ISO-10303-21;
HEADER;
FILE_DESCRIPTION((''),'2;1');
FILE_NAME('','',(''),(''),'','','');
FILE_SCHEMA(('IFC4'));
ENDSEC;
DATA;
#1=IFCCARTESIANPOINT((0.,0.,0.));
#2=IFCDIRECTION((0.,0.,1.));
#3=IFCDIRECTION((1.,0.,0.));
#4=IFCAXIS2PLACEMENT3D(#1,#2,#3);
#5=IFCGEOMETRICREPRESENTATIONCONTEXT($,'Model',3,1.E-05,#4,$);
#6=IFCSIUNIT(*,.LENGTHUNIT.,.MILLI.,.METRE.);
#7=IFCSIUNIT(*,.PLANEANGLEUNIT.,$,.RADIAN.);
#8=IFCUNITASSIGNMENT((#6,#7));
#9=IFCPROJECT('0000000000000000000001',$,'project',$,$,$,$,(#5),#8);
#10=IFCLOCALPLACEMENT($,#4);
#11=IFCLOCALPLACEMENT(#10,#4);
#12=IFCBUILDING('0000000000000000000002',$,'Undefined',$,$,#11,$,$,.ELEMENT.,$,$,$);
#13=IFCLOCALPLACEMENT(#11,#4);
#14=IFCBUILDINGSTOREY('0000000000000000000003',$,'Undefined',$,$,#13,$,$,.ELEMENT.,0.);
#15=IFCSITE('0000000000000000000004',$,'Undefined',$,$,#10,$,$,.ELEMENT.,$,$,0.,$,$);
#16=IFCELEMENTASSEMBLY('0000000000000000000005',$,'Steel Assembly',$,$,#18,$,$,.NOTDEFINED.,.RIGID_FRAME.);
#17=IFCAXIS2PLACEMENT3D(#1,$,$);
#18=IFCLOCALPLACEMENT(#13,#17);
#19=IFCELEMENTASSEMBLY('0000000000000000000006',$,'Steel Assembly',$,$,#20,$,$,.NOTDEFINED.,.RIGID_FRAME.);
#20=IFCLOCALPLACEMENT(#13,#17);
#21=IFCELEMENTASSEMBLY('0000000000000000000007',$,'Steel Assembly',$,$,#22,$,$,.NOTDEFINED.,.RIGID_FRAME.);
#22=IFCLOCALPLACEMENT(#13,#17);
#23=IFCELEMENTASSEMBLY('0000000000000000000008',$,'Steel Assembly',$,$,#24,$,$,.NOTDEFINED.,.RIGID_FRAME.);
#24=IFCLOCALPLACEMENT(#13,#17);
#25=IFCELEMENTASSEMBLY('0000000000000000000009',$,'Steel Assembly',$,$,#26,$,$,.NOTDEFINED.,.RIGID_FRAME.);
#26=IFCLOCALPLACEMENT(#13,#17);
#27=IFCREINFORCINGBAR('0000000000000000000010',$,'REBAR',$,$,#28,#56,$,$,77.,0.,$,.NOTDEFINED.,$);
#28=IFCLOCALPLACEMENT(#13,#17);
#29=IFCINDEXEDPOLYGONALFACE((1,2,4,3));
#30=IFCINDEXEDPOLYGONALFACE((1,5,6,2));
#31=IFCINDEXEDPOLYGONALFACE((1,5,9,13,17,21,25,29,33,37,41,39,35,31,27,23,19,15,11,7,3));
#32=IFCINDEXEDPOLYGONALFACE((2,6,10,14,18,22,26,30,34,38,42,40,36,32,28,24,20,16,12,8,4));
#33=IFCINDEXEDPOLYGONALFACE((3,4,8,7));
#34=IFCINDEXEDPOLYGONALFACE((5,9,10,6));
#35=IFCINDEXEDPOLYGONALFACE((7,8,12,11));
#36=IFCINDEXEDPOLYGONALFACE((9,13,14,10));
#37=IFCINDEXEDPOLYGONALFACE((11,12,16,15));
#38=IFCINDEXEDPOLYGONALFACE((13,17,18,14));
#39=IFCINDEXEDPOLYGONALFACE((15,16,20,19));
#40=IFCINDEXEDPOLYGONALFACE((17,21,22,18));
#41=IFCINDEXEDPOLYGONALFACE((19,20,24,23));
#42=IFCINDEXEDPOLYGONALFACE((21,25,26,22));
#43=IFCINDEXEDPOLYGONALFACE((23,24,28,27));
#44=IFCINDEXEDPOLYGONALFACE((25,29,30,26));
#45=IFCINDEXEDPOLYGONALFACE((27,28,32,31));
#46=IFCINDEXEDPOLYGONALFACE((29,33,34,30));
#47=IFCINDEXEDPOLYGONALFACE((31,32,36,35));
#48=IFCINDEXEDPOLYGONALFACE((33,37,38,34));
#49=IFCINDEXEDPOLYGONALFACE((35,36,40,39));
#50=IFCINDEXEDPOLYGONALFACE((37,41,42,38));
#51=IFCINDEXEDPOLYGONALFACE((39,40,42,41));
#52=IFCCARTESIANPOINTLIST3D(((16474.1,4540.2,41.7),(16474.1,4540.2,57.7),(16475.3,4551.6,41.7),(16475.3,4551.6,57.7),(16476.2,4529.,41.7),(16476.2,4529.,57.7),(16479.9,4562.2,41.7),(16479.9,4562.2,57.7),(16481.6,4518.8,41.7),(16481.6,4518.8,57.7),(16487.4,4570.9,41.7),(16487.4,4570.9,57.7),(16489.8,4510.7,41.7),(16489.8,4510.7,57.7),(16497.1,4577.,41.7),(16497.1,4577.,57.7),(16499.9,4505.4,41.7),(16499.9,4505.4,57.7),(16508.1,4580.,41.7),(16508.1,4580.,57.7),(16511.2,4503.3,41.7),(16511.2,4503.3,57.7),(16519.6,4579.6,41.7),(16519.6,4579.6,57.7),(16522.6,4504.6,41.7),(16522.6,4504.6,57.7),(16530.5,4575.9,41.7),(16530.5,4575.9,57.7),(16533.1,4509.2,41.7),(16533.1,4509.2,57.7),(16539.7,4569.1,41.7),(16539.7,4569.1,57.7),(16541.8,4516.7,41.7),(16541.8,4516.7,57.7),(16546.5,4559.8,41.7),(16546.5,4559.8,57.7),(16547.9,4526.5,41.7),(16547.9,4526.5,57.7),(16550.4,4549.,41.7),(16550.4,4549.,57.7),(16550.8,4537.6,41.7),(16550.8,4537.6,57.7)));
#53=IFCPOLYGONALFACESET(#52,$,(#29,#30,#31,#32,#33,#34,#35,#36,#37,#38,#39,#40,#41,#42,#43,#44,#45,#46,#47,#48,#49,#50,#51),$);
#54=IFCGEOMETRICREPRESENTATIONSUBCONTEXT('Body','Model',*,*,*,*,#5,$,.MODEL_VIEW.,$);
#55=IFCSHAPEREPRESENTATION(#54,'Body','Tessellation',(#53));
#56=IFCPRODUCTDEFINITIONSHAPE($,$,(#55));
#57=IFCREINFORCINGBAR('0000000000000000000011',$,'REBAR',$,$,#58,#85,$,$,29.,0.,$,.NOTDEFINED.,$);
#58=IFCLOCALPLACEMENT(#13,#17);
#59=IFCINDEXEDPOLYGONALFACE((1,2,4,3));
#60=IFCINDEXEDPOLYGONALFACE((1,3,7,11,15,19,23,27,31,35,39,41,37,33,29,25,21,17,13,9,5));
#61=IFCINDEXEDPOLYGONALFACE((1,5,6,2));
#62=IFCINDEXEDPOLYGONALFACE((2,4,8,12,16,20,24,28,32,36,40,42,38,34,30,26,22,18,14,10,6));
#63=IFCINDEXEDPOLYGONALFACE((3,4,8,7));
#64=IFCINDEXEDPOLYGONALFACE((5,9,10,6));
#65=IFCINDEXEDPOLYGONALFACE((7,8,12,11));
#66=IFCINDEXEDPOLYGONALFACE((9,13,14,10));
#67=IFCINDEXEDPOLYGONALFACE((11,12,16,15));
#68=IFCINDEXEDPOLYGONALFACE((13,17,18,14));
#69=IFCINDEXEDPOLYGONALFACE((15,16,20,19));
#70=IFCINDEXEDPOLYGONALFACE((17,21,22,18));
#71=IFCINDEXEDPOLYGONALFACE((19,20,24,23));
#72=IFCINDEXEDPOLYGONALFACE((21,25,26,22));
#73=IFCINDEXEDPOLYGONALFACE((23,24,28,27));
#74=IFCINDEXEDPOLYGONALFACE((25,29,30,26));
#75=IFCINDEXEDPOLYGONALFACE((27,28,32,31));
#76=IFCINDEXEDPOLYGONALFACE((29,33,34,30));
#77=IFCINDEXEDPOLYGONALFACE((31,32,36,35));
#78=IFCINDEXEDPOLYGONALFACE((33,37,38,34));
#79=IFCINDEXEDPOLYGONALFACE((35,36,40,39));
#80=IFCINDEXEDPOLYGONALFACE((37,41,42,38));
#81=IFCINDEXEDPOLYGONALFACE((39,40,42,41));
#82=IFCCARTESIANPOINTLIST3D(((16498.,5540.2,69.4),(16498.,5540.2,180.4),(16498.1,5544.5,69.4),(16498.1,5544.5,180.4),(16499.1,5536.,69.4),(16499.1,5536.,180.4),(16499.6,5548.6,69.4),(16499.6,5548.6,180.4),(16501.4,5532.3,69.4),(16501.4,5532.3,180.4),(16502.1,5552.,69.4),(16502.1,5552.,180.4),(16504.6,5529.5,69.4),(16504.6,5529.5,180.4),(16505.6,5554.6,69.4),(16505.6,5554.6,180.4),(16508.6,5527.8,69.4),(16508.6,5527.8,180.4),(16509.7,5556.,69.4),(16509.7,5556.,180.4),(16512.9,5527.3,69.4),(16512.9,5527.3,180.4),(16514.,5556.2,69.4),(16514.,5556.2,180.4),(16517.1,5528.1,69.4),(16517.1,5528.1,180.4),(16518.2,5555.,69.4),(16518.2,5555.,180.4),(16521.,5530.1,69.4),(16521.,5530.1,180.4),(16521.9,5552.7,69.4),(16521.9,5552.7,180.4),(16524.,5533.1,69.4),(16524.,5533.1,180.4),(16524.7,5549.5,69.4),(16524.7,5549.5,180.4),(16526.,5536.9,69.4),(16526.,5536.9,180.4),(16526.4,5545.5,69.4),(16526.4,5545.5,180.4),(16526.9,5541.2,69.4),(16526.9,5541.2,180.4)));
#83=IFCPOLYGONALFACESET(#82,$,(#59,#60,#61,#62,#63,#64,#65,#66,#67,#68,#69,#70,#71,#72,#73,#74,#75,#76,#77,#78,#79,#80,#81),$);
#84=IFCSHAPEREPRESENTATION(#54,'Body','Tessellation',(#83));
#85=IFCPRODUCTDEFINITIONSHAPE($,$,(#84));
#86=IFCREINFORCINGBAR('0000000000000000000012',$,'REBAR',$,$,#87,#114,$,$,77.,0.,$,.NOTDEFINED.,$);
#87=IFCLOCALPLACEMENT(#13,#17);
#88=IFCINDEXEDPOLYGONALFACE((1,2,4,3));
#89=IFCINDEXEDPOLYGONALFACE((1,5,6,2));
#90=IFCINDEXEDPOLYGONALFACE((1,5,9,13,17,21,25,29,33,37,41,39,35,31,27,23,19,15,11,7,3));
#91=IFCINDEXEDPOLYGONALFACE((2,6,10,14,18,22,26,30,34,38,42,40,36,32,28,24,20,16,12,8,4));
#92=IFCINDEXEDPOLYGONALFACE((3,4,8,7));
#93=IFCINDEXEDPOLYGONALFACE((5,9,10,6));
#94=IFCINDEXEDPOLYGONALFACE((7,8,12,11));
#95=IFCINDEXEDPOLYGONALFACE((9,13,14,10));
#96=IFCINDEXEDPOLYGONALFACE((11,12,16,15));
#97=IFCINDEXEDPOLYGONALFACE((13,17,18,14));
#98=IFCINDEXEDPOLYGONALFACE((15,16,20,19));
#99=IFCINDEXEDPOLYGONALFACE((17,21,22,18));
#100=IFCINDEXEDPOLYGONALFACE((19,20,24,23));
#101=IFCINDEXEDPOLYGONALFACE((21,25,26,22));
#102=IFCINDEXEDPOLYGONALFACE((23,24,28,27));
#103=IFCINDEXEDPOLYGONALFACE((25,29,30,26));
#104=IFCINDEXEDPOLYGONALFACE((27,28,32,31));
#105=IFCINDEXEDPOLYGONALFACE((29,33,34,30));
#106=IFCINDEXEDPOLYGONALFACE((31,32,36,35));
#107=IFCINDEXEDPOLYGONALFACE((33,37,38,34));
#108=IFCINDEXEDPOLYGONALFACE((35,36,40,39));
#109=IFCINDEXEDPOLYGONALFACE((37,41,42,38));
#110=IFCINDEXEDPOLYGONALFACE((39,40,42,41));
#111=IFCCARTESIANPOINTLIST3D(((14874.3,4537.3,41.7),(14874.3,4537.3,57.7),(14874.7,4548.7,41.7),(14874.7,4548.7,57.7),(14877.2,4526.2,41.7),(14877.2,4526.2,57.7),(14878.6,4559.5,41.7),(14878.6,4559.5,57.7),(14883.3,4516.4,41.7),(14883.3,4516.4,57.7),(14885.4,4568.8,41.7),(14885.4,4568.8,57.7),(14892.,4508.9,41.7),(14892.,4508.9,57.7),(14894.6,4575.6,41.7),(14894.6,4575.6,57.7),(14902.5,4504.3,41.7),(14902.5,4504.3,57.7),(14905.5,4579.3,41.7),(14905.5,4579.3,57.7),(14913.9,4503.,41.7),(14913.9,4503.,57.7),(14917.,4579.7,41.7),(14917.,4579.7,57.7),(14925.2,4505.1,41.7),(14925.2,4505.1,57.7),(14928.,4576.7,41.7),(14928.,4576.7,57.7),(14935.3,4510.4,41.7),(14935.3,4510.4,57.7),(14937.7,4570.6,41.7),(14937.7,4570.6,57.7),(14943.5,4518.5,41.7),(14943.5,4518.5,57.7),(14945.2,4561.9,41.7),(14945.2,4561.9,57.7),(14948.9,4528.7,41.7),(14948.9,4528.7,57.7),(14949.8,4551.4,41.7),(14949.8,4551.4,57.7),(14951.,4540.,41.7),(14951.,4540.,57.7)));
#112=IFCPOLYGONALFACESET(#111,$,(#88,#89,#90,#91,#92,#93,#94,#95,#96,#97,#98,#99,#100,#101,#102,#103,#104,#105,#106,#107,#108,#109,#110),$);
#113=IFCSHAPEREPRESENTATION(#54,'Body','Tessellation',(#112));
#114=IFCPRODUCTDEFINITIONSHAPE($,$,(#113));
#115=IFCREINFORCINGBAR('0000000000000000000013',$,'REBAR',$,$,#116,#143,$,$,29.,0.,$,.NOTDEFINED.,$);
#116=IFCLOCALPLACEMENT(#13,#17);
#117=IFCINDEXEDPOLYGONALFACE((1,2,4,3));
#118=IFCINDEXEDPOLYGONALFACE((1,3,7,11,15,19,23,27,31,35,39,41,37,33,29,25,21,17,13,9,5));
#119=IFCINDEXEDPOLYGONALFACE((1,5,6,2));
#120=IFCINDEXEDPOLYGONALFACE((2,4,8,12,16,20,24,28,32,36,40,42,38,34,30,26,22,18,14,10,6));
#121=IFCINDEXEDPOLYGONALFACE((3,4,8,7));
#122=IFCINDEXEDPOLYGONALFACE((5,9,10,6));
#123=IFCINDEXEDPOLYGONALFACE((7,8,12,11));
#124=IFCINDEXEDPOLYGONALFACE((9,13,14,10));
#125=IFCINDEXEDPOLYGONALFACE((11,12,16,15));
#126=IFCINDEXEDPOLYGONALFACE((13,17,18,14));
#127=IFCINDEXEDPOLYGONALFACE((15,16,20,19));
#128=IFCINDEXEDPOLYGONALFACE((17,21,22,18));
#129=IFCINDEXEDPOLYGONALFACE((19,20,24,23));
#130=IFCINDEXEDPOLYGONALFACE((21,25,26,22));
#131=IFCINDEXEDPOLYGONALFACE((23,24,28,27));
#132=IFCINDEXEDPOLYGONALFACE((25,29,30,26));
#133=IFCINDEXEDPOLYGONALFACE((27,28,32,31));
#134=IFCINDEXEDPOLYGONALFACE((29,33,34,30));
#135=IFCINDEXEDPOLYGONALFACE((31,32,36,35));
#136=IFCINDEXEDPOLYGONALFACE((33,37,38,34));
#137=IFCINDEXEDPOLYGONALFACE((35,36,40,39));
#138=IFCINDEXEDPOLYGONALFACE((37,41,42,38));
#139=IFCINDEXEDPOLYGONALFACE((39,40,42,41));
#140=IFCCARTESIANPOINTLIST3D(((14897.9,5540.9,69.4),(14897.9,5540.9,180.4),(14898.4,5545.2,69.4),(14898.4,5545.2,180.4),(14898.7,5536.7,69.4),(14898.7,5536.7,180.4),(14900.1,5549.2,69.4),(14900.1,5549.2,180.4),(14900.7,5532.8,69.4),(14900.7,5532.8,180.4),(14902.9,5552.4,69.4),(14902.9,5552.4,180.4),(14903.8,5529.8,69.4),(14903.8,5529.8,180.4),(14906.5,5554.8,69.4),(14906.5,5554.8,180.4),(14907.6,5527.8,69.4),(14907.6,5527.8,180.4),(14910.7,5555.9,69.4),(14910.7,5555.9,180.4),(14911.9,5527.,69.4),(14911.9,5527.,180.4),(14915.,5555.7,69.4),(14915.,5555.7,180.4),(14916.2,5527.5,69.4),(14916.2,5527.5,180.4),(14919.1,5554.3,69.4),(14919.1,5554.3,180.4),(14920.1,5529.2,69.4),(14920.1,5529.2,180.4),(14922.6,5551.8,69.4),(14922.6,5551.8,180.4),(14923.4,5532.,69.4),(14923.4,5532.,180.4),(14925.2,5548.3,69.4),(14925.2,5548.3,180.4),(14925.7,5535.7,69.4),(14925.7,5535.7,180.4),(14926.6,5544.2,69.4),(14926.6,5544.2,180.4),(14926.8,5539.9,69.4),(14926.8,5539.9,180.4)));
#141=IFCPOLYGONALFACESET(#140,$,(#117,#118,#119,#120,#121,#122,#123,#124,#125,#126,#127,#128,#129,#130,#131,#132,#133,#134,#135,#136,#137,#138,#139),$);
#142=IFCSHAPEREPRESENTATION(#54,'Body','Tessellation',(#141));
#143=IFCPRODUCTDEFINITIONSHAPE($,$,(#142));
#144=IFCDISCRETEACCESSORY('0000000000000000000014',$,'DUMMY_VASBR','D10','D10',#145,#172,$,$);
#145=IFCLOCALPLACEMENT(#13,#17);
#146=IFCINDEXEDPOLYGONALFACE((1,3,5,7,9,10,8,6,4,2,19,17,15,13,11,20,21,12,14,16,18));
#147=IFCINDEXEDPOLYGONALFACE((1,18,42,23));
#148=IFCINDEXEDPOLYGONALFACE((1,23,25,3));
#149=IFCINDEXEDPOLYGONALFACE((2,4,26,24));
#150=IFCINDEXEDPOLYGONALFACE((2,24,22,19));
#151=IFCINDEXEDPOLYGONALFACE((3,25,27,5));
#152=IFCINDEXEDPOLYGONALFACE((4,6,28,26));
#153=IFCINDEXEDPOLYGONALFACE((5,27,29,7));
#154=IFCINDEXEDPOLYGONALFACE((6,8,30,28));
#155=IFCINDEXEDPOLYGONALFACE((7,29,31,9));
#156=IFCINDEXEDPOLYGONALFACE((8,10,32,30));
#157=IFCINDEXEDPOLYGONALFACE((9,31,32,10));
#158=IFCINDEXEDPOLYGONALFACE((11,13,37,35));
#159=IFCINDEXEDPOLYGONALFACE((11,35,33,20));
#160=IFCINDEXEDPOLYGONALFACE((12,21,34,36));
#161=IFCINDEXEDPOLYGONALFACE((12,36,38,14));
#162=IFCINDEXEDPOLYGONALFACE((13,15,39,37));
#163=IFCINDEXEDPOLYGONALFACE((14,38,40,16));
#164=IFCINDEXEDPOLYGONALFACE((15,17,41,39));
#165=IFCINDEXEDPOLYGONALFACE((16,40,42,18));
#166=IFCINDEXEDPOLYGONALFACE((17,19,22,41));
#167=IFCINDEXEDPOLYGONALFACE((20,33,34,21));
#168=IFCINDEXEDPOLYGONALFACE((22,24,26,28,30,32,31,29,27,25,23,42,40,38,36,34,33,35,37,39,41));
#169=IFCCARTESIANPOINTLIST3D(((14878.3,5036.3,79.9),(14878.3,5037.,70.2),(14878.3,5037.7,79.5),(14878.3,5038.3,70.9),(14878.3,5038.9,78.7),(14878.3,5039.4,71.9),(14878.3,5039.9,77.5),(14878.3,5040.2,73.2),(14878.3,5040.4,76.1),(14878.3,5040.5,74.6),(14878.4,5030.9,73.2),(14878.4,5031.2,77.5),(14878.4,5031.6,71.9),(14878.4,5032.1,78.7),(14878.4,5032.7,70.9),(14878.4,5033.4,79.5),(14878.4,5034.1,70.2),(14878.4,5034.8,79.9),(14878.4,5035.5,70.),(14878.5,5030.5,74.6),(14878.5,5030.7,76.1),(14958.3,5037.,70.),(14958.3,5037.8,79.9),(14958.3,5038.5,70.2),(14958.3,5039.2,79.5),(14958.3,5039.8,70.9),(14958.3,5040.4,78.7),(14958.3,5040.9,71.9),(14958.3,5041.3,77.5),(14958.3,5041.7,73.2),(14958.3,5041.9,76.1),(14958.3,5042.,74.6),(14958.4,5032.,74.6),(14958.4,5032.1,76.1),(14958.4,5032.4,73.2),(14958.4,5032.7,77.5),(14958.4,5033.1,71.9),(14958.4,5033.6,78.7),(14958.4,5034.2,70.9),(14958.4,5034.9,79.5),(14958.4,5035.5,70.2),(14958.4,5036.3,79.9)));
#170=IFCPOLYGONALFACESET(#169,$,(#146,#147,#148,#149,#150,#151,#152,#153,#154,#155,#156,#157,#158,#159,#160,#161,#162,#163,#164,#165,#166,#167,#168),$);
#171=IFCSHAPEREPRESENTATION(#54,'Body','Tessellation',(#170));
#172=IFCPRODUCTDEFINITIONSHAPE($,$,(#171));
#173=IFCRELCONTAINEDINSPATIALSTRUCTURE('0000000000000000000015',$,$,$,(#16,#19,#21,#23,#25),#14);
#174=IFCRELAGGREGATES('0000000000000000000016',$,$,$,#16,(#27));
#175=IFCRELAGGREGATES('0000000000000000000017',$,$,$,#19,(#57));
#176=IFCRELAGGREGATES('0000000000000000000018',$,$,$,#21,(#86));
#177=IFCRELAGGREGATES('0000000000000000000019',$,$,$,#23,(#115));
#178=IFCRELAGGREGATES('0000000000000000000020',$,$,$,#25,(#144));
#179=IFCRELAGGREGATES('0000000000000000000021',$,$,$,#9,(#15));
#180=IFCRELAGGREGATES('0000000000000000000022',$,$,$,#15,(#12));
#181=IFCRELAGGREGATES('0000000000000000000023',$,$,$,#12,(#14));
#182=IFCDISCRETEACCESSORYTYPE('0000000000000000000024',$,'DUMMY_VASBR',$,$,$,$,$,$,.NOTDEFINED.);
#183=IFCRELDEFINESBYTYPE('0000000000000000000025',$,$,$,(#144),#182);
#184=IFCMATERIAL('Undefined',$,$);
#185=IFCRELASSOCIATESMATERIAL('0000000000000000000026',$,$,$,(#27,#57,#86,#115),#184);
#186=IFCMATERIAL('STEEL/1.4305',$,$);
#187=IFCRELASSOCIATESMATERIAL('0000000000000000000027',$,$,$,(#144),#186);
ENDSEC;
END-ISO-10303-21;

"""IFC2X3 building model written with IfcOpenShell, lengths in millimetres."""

from ifc_helpers import new_model, entity, si_unit, frame, origin_with_axes, origin_2d_with_axis, place, context, subcontext, project, spatial, circle, extrude, source, transform, mapped, material, type_object, element, aggregate, save


model = new_model("IFC2X3")

# Units and contexts
model_context = context("Model", 3, precision=1e-05, world=origin_with_axes())
body_context = subcontext(model_context, "Body", "Model", "MODEL_VIEW")
ifc_project = project(units=[si_unit("LENGTHUNIT", "METRE", prefix="MILLI"), si_unit("PLANEANGLEUNIT", "RADIAN")], contexts=[model_context])

# Site, building, storey
site_placement = place(None, origin_with_axes())
site = spatial("IfcSite", under=ifc_project, at=site_placement, Name="Undefined", CompositionType="ELEMENT", RefElevation=0.0)
building_placement = place(site_placement, origin_with_axes())
building = spatial("IfcBuilding", under=site, at=building_placement, Name="Undefined", CompositionType="ELEMENT")
storey_placement = place(building_placement, origin_with_axes())
storey = spatial("IfcBuildingStorey", under=building, at=storey_placement, Name="Undefined", CompositionType="ELEMENT", Elevation=0.0)

# Element assemblies
assembly_1_placement = place(storey_placement, origin_with_axes())
assembly_1 = element("IfcElementAssembly", 1, at=assembly_1_placement, inside=storey, Name="Steel Assembly", AssemblyPlace="NOTDEFINED", PredefinedType="RIGID_FRAME")
assembly_2_placement = place(storey_placement, origin_with_axes())
assembly_2 = element("IfcElementAssembly", 2, at=assembly_2_placement, inside=storey, Name="Steel Assembly", AssemblyPlace="NOTDEFINED", PredefinedType="RIGID_FRAME")
assembly_3_placement = place(storey_placement, origin_with_axes())
assembly_3 = element("IfcElementAssembly", 3, at=assembly_3_placement, inside=storey, Name="Steel Assembly", AssemblyPlace="NOTDEFINED", PredefinedType="RIGID_FRAME")
assembly_4_placement = place(storey_placement, origin_with_axes())
assembly_4 = element("IfcElementAssembly", 4, at=assembly_4_placement, inside=storey, Name="Steel Assembly", AssemblyPlace="NOTDEFINED", PredefinedType="RIGID_FRAME")
assembly_5_placement = place(storey_placement, origin_with_axes())
assembly_5 = element("IfcElementAssembly", 5, at=assembly_5_placement, inside=storey, Name="Steel Assembly", AssemblyPlace="NOTDEFINED", PredefinedType="RIGID_FRAME")
ifc_material_1 = material(Name="STEEL/1.4305")

# Shared definitions
ifc_material_2 = material(Name="Undefined")

# Reinforcing bars
shared_shape_1 = source(origin_with_axes(), body_context, "Body", "AdvancedSweptSolid", [
    entity("IfcSweptDiskSolid", entity("IfcTrimmedCurve", entity("IfcLine", entity("IfcCartesianPoint", [0.0, 0.0, 0.0]), entity("IfcVector", entity("IfcDirection", [1.0, 0.0, 0.0]), 1.0)), [entity("IfcParameterValue", 0.0)], [entity("IfcParameterValue", 16.0)], True, "PARAMETER"), 38.5, None, 0.0, 16.0),
])
reinforcing_bar_1_placement = place(assembly_1_placement, frame((16512.6, 4541.8, 41.7), z_axis=(-0.848095, 0.529844, 0.0), x_axis=(0.0, 0.0, 1.0)))
reinforcing_bar_1 = element("IfcReinforcingBar", 6, at=reinforcing_bar_1_placement, material=ifc_material_2, Name="REBAR", BarRole="NOTDEFINED", CrossSectionArea=0.0, NominalDiameter=77.0, context=body_context, shape_type="MappedRepresentation", body=[
    mapped(shared_shape_1, transform((0.0, 0.0, 0.0))),
])
aggregate(assembly_1, [reinforcing_bar_1])
shared_shape_2 = source(origin_with_axes(), body_context, "Body", "AdvancedSweptSolid", [
    entity("IfcSweptDiskSolid", entity("IfcTrimmedCurve", entity("IfcLine", entity("IfcCartesianPoint", [0.0, 0.0, 0.0]), entity("IfcVector", entity("IfcDirection", [1.0, 0.0, 0.0]), 1.0)), [entity("IfcParameterValue", 0.0)], [entity("IfcParameterValue", 111.0)], True, "PARAMETER"), 14.5, None, 0.0, 111.0),
])
reinforcing_bar_2_placement = place(assembly_2_placement, frame((16512.4, 5541.8, 180.4), z_axis=(0.847901, 0.530154, 0.0), x_axis=(0.0, 0.0, -1.0)))
reinforcing_bar_2 = element("IfcReinforcingBar", 7, at=reinforcing_bar_2_placement, material=ifc_material_2, Name="REBAR", BarRole="NOTDEFINED", CrossSectionArea=0.0, NominalDiameter=29.0, context=body_context, shape_type="MappedRepresentation", body=[
    mapped(shared_shape_2, transform((0.0, 0.0, 0.0))),
])
aggregate(assembly_2, [reinforcing_bar_2])
shared_shape_3 = source(origin_with_axes(), body_context, "Body", "AdvancedSweptSolid", [
    entity("IfcSweptDiskSolid", entity("IfcTrimmedCurve", entity("IfcLine", entity("IfcCartesianPoint", [0.0, 0.0, 0.0]), entity("IfcVector", entity("IfcDirection", [1.0, 0.0, 0.0]), 1.0)), [entity("IfcParameterValue", 0.0)], [entity("IfcParameterValue", 16.0)], True, "PARAMETER"), 38.5, None, 0.0, 16.0),
])
reinforcing_bar_3_placement = place(assembly_3_placement, frame((14912.6, 4541.5, 41.7), z_axis=(0.847901, 0.530154, 0.0), x_axis=(0.0, 0.0, 1.0)))
reinforcing_bar_3 = element("IfcReinforcingBar", 8, at=reinforcing_bar_3_placement, material=ifc_material_2, Name="REBAR", BarRole="NOTDEFINED", CrossSectionArea=0.0, NominalDiameter=77.0, context=body_context, shape_type="MappedRepresentation", body=[
    mapped(shared_shape_3, transform((0.0, 0.0, 0.0))),
])
aggregate(assembly_3, [reinforcing_bar_3])
shared_shape_4 = source(origin_with_axes(), body_context, "Body", "AdvancedSweptSolid", [
    entity("IfcSweptDiskSolid", entity("IfcTrimmedCurve", entity("IfcLine", entity("IfcCartesianPoint", [0.0, 0.0, 0.0]), entity("IfcVector", entity("IfcDirection", [1.0, 0.0, 0.0]), 1.0)), [entity("IfcParameterValue", 0.0)], [entity("IfcParameterValue", 111.0)], True, "PARAMETER"), 14.5, None, 0.0, 111.0),
])
reinforcing_bar_4_placement = place(assembly_4_placement, frame((14912.4, 5541.5, 180.4), z_axis=(-0.848095, 0.529844, 0.0), x_axis=(0.0, 0.0, -1.0)))
reinforcing_bar_4 = element("IfcReinforcingBar", 9, at=reinforcing_bar_4_placement, material=ifc_material_2, Name="REBAR", BarRole="NOTDEFINED", CrossSectionArea=0.0, NominalDiameter=29.0, context=body_context, shape_type="MappedRepresentation", body=[
    mapped(shared_shape_4, transform((0.0, 0.0, 0.0))),
])
aggregate(assembly_4, [reinforcing_bar_4])

# Discrete accessory
discrete_accessory_type_1 = type_object("IfcDiscreteAccessoryType", Name="DUMMY_VASBR")
discrete_accessory_1_placement = place(assembly_5_placement, frame((14958.3, 5037.0, 75.0), z_axis=(-0.018576, 0.999827, 0.0), x_axis=(-0.999827, -0.018576, 0.0)))
discrete_accessory_1 = element("IfcDiscreteAccessory", 10, at=discrete_accessory_1_placement, type_object=discrete_accessory_type_1, material=ifc_material_1, Name="DUMMY_VASBR", Description="D10", ObjectType="D10", context=body_context, shape_type="SweptSolid", body=[
    extrude(circle(Radius=5.0, at=origin_2d_with_axis()), frame((80.0, 0.0, 0.0), z_axis=(-1.0, 0.0, 0.0), x_axis=(0.0, -1.0, 0.0)), (0.0, 0.0, 1.0), 80.0),
])
aggregate(assembly_5, [discrete_accessory_1])

save(model, "model.ifc")
